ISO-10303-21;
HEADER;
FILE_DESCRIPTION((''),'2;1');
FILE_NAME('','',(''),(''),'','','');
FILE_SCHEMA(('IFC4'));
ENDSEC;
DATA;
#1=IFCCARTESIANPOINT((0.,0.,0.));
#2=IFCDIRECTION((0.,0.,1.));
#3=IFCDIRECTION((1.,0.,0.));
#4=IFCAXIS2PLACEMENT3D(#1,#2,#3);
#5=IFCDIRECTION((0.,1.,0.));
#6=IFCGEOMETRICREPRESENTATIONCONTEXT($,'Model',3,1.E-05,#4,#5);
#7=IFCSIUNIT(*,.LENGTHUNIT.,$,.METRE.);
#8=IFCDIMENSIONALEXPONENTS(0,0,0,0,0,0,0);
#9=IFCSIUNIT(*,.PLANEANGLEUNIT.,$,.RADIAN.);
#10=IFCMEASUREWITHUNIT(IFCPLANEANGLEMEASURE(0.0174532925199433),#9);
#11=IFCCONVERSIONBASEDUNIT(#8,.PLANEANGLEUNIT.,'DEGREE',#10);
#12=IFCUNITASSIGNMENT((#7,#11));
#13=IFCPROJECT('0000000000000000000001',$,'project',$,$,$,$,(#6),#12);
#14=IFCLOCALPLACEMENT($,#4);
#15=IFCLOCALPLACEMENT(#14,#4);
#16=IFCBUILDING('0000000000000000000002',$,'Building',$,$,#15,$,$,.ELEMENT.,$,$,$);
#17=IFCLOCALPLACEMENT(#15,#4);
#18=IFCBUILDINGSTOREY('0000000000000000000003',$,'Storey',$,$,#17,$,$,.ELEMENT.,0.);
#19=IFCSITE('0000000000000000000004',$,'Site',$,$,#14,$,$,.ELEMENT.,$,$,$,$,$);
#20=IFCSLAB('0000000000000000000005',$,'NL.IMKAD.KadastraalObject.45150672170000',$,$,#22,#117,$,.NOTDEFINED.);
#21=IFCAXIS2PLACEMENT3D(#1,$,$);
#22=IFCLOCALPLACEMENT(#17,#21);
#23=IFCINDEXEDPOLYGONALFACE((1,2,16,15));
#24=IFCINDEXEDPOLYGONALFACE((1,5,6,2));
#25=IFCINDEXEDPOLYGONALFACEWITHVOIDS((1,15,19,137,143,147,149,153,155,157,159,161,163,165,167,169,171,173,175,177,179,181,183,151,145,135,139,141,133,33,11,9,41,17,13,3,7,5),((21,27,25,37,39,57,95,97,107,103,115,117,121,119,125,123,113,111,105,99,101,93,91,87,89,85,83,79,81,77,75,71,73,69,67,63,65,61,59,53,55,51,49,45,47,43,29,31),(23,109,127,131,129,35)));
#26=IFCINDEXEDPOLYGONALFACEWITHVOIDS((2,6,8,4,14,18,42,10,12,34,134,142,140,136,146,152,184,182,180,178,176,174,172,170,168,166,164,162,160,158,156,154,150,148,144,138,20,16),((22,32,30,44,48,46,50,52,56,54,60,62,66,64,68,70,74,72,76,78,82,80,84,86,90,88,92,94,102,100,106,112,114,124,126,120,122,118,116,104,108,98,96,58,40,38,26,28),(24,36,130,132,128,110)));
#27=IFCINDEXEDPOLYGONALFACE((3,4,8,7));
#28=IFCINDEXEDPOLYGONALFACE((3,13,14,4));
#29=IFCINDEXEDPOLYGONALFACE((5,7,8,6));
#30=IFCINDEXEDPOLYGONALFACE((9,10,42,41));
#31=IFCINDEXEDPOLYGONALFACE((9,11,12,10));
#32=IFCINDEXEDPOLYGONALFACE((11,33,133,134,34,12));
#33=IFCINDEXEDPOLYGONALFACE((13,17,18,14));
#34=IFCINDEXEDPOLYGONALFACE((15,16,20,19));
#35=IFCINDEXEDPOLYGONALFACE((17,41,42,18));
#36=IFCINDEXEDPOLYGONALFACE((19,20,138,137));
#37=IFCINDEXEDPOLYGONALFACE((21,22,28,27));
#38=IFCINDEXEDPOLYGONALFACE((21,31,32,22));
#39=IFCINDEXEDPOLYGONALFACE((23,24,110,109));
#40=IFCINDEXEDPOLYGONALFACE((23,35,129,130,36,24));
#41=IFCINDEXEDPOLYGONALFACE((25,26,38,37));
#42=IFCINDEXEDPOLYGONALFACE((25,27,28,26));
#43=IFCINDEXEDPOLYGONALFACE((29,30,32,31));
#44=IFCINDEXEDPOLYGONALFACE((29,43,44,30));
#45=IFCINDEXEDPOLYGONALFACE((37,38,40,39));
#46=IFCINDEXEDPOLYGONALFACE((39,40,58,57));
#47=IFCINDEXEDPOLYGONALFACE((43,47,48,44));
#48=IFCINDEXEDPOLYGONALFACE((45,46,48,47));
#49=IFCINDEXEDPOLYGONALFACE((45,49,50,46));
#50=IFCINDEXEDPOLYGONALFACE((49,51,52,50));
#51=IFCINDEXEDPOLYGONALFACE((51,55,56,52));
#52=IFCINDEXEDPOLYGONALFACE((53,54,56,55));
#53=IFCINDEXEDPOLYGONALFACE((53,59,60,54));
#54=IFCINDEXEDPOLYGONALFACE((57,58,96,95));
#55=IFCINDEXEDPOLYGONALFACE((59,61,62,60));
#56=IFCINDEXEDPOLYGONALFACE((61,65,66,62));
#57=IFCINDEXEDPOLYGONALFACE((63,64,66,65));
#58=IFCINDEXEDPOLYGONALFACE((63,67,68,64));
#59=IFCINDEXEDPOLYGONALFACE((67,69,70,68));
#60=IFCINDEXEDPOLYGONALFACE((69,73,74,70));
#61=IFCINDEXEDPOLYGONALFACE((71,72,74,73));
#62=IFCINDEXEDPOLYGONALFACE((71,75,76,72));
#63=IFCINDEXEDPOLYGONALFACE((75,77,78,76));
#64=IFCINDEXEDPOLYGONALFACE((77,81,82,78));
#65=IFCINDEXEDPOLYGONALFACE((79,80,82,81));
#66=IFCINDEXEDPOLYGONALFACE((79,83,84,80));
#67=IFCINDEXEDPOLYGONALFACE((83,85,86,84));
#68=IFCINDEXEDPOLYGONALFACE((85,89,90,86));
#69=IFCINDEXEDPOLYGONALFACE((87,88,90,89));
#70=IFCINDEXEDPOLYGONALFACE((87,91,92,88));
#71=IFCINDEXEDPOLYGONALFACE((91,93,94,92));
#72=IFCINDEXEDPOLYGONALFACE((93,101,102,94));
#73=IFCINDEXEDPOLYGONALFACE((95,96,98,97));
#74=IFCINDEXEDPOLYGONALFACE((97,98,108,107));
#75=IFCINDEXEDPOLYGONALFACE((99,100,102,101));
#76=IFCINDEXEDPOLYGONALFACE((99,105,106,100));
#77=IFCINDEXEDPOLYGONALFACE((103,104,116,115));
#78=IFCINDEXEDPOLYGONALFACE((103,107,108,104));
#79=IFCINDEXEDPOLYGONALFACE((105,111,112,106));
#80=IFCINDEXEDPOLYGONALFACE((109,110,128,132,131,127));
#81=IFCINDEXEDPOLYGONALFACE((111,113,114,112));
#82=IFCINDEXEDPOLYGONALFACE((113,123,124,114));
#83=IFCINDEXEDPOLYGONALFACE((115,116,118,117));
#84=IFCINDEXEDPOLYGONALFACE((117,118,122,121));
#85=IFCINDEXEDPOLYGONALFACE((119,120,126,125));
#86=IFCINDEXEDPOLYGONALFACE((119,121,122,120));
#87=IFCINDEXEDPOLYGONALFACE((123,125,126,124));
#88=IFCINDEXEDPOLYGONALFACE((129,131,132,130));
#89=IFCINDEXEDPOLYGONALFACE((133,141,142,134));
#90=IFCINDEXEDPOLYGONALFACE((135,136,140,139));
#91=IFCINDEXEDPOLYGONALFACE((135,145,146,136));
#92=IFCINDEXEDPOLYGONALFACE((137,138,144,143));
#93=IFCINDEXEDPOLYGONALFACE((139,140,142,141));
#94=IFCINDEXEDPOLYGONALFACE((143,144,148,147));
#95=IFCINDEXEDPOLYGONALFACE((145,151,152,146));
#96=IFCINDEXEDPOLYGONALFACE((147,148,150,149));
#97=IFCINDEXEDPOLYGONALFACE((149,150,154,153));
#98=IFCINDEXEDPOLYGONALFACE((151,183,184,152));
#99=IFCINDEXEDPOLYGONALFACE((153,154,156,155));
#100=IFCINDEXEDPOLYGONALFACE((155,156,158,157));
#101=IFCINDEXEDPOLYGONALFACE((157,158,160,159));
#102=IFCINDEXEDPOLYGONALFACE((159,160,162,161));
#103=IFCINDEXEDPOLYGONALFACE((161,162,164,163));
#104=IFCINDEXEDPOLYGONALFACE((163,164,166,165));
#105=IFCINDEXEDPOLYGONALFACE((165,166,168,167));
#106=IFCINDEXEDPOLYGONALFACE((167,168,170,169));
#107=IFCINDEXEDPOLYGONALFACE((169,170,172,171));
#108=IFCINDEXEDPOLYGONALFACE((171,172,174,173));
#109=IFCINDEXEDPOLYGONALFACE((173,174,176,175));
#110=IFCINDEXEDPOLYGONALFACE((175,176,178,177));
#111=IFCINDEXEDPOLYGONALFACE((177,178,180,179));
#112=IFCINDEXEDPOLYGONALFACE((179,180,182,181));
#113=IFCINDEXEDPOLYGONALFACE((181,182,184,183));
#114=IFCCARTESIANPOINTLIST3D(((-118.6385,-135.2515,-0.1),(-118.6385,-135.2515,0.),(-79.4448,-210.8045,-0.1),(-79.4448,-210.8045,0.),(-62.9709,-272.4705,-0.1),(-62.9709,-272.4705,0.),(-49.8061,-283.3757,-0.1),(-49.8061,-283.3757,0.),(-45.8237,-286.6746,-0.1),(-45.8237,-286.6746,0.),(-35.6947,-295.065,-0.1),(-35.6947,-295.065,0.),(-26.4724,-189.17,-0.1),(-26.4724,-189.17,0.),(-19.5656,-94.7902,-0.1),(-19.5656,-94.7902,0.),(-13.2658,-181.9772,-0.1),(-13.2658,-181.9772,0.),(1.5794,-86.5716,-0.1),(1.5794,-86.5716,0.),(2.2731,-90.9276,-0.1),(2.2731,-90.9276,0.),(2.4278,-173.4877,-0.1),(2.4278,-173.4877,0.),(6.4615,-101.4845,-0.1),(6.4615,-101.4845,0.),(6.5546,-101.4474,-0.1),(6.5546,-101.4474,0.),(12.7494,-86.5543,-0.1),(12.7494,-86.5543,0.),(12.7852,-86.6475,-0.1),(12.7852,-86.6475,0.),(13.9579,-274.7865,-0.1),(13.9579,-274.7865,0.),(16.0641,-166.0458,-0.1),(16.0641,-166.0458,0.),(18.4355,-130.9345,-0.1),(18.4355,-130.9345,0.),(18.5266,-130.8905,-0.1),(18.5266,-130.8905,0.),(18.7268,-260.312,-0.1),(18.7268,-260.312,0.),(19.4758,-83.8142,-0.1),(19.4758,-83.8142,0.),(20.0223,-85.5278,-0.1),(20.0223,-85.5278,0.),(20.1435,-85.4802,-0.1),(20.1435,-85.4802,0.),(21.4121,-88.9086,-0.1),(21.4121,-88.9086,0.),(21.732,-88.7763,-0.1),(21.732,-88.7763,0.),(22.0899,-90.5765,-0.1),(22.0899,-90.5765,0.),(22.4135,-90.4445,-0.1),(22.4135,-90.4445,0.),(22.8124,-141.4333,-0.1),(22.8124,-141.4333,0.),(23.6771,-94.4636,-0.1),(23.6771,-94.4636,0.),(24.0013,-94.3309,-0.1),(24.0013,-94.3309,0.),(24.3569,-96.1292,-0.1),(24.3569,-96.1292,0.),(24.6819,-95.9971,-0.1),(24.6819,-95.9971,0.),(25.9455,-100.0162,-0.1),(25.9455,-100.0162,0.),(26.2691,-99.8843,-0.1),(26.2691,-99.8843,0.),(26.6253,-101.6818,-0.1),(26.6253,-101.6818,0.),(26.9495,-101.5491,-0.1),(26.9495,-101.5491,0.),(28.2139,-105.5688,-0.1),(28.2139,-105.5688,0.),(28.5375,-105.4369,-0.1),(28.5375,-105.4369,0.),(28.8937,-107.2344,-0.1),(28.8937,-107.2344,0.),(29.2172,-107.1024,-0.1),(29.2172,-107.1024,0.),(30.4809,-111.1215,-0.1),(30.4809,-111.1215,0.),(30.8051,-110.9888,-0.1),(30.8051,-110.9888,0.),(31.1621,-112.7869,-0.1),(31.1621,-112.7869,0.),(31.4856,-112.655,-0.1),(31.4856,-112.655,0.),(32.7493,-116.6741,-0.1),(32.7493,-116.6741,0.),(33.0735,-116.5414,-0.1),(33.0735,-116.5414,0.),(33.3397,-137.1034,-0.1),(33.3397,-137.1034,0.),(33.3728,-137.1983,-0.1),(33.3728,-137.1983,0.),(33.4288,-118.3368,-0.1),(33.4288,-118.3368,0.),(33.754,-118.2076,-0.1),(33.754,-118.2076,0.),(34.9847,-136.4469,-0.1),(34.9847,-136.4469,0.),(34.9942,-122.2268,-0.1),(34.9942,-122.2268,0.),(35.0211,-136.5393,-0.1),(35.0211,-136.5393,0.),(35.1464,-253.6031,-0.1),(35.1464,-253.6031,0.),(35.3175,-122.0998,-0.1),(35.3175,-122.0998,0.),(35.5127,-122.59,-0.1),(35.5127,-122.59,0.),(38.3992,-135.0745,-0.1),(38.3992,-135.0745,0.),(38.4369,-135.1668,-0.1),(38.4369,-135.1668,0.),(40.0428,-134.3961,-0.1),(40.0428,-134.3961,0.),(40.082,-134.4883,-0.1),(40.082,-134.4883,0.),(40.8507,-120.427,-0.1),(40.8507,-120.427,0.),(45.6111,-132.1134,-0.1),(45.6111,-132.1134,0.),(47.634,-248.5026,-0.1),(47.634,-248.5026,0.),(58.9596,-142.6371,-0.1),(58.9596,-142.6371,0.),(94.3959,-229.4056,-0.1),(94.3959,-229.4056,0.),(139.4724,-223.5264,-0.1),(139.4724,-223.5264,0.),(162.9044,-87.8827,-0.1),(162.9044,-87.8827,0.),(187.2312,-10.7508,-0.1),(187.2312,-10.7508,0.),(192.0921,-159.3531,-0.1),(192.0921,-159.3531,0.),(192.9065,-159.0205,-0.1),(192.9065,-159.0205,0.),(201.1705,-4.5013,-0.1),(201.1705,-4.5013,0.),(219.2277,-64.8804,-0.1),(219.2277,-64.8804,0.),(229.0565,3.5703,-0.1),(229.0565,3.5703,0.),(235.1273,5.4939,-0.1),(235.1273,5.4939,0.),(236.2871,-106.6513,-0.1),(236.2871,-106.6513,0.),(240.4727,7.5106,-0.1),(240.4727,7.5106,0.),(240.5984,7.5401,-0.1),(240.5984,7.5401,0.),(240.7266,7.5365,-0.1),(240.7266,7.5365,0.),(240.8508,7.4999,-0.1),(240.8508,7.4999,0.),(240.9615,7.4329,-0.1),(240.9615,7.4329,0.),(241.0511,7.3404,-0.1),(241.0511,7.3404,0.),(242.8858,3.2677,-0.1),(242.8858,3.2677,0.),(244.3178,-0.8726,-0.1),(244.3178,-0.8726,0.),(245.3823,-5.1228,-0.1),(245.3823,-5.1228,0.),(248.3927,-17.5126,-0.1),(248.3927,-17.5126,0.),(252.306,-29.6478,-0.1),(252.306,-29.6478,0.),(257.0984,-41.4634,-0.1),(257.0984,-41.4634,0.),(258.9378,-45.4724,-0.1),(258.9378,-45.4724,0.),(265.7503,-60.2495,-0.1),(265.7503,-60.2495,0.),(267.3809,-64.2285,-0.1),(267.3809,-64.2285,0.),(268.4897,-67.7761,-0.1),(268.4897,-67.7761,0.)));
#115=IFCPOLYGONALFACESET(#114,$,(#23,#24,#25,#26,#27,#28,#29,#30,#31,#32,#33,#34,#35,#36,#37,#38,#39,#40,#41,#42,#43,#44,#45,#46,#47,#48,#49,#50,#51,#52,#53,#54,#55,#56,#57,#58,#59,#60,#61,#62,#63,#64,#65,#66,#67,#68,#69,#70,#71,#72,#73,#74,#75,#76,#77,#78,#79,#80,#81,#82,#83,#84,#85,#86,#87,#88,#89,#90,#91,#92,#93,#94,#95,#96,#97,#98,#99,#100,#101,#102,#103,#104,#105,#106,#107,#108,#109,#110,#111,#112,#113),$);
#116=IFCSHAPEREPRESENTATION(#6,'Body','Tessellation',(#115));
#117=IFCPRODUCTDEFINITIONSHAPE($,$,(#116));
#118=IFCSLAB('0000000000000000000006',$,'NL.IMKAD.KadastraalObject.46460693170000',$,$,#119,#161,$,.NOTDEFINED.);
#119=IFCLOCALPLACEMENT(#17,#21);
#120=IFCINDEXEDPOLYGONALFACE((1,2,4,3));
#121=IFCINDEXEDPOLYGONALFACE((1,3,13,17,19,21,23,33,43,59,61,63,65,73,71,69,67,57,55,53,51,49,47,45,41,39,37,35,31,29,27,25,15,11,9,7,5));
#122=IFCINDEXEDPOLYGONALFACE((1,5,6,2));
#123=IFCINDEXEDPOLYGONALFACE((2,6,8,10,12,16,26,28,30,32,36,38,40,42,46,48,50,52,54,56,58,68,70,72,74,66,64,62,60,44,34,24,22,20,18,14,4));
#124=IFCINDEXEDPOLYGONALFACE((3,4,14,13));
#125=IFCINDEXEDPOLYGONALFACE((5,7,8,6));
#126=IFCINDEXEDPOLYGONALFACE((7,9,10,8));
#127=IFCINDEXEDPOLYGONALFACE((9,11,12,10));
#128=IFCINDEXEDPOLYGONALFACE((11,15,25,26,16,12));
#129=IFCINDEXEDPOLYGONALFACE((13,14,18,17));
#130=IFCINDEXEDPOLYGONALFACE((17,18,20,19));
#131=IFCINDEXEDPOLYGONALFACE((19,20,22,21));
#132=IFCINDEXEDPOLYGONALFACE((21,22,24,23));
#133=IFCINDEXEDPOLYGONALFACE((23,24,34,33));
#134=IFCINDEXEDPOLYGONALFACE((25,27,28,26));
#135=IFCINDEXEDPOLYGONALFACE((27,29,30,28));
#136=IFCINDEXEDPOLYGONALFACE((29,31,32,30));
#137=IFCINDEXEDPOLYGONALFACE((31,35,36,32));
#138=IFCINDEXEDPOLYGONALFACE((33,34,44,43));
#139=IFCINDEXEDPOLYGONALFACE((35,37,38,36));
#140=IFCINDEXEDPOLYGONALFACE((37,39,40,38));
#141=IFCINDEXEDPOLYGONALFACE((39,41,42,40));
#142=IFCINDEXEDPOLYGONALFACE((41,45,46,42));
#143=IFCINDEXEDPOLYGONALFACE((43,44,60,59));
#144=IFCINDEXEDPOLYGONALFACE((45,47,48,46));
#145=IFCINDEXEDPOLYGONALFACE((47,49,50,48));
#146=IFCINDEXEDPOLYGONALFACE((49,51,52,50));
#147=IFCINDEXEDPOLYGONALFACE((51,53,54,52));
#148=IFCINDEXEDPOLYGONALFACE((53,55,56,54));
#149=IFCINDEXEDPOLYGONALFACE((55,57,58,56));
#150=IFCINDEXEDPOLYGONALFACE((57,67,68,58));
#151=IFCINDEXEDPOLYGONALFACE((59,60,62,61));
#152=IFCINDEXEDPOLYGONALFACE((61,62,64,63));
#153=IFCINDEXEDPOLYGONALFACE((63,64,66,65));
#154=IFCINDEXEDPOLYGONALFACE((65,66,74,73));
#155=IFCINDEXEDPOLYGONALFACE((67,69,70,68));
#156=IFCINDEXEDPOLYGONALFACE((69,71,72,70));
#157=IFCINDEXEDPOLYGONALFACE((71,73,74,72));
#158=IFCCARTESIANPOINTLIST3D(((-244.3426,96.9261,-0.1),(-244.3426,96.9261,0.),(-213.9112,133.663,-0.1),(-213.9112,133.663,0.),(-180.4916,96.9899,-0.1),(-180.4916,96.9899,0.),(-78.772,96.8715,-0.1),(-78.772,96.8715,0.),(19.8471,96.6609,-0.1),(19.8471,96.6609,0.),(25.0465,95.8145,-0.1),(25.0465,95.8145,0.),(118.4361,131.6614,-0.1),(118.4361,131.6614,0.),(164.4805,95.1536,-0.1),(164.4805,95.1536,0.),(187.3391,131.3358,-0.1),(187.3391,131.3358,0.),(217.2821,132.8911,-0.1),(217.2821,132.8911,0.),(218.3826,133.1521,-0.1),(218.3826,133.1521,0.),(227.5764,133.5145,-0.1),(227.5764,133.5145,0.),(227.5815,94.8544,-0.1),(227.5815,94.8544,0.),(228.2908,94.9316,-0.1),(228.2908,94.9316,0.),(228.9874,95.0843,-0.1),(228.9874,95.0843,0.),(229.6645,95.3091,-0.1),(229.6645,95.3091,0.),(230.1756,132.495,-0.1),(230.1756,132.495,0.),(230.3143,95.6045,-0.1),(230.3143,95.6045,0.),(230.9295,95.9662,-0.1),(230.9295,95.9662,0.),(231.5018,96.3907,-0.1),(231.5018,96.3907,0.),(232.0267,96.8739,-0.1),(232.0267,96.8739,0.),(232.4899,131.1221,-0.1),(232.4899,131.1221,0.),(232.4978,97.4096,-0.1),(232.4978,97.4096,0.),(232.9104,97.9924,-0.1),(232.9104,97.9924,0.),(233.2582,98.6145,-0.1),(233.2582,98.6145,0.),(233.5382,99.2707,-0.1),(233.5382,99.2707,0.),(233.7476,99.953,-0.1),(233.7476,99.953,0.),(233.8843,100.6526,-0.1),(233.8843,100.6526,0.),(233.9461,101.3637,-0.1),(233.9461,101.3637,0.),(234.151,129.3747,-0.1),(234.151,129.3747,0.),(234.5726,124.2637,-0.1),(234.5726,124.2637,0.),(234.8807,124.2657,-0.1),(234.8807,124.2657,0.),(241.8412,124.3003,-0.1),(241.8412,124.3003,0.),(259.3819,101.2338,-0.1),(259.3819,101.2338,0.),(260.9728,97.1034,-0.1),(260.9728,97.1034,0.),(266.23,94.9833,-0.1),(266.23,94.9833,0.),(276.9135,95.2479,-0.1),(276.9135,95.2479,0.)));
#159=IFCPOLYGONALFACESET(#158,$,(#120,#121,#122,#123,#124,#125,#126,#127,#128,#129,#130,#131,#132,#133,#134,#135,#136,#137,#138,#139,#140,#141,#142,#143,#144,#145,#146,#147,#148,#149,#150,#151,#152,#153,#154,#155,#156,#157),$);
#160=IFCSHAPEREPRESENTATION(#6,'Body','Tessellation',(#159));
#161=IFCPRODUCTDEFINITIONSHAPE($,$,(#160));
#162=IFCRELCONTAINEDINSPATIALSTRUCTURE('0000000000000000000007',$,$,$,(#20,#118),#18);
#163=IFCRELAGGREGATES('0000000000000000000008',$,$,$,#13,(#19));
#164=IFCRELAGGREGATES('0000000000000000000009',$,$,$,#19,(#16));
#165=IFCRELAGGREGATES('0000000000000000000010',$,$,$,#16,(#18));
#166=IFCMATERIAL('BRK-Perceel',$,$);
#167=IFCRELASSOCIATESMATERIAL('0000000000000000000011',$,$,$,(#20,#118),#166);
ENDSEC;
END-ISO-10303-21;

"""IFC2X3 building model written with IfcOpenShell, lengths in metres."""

from ifc_helpers import new_model, entity, si_unit, converted_unit, direction, frame, origin_with_axes, place, context, project, spatial, polyline, outline, extrude, material, element, save


model = new_model("IFC2X3")

# Units and contexts
model_context = context("Model", 3, precision=1e-05, world=origin_with_axes(), true_north=direction((0.0, 1.0, 0.0)))
ifc_project = project(units=[si_unit("LENGTHUNIT", "METRE"), converted_unit("PLANEANGLEUNIT", "DEGREE", entity("IfcPlaneAngleMeasure", 0.0174532925199433), si_unit("PLANEANGLEUNIT", "RADIAN"), dimensions=[0, 0, 0, 0, 0, 0, 0])], contexts=[model_context])

# Site, building, storey
site_placement = place(None, origin_with_axes())
site = spatial("IfcSite", under=ifc_project, at=site_placement, Name="Site", CompositionType="ELEMENT")
building_placement = place(site_placement, origin_with_axes())
building = spatial("IfcBuilding", under=site, at=building_placement, Name="Building", CompositionType="ELEMENT")
storey_placement = place(building_placement, origin_with_axes())
storey = spatial("IfcBuildingStorey", under=building, at=storey_placement, Name="Storey", CompositionType="ELEMENT", Elevation=0.0)

# Slabs
ifc_material = material(Name="BRK-Perceel")
slab_1_placement = place(storey_placement, frame((0.0, 0.0, -0.1), z_axis=(0.0, 0.0, 1.0), x_axis=(1.0, 0.0, 0.0)))
element("IfcSlab", 1, at=slab_1_placement, inside=storey, material=ifc_material, Name="NL.IMKAD.KadastraalObject.45150672170000", PredefinedType="NOTDEFINED", context=model_context, shape_type="SweptSolid", body=[
    extrude(outline(polyline([(13.9579, -274.7865), (-35.6947, -295.065), (-45.8237, -286.6746), (18.7268, -260.312), (-13.2658, -181.9772), (-26.4724, -189.17), (-79.4448, -210.8045), (-49.8061, -283.3757), (-62.9709, -272.4705), (-118.6385, -135.2515), (-19.5656, -94.7902), (1.5794, -86.5716), (187.2312, -10.7508), (201.1705, -4.5013), (229.0565, 3.5703), (235.1273, 5.4939), (240.4727, 7.5106), (240.5984, 7.5401), (240.7266, 7.5365), (240.8508, 7.4999), (240.9615, 7.4329), (241.0511, 7.3404), (242.8858, 3.2677), (244.3178, -0.8726), (245.3823, -5.1228), (248.3927, -17.5126), (252.306, -29.6478), (257.0984, -41.4634), (258.9378, -45.4724), (265.7503, -60.2495), (267.3809, -64.2285), (268.4897, -67.7761), (236.2871, -106.6513), (219.2277, -64.8804), (162.9044, -87.8827), (192.0921, -159.3531), (192.9065, -159.0205), (139.4724, -223.5264), (13.9579, -274.7865)]), holes=[polyline([(94.3959, -229.4056), (58.9596, -142.6371), (16.0641, -166.0458), (2.4278, -173.4877), (35.1464, -253.6031), (47.634, -248.5026), (94.3959, -229.4056)]), polyline([(33.3397, -137.1034), (33.3728, -137.1983), (35.0211, -136.5393), (34.9847, -136.4469), (38.3992, -135.0745), (38.4369, -135.1668), (40.082, -134.4883), (40.0428, -134.3961), (45.6111, -132.1134), (40.8507, -120.427), (35.5127, -122.59), (35.3175, -122.0998), (34.9942, -122.2268), (33.4288, -118.3368), (33.754, -118.2076), (33.0735, -116.5414), (32.7493, -116.6741), (31.1621, -112.7869), (31.4856, -112.655), (30.8051, -110.9888), (30.4809, -111.1215), (28.8937, -107.2344), (29.2172, -107.1024), (28.5375, -105.4369), (28.2139, -105.5688), (26.6253, -101.6818), (26.9495, -101.5491), (26.2691, -99.8843), (25.9455, -100.0162), (24.3569, -96.1292), (24.6819, -95.9971), (24.0013, -94.3309), (23.6771, -94.4636), (22.0899, -90.5765), (22.4135, -90.4445), (21.732, -88.7763), (21.4121, -88.9086), (20.0223, -85.5278), (20.1435, -85.4802), (19.4758, -83.8142), (12.7494, -86.5543), (12.7852, -86.6475), (2.2731, -90.9276), (6.5546, -101.4474), (6.4615, -101.4845), (18.4355, -130.9345), (18.5266, -130.8905), (22.8124, -141.4333), (33.3397, -137.1034)])]), origin_with_axes(), (0.0, 0.0, 1.0), 0.1),
])
slab_2_placement = place(storey_placement, frame((0.0, 0.0, -0.1), z_axis=(0.0, 0.0, 1.0), x_axis=(1.0, 0.0, 0.0)))
element("IfcSlab", 2, at=slab_2_placement, inside=storey, material=ifc_material, Name="NL.IMKAD.KadastraalObject.46460693170000", PredefinedType="NOTDEFINED", context=model_context, shape_type="SweptSolid", body=[
    extrude(outline(polyline([(266.23, 94.9833), (260.9728, 97.1034), (259.3819, 101.2338), (233.9461, 101.3637), (233.8843, 100.6526), (233.7476, 99.953), (233.5382, 99.2707), (233.2582, 98.6145), (232.9104, 97.9924), (232.4978, 97.4096), (232.0267, 96.8739), (231.5018, 96.3907), (230.9295, 95.9662), (230.3143, 95.6045), (229.6645, 95.3091), (228.9874, 95.0843), (228.2908, 94.9316), (227.5815, 94.8544), (164.4805, 95.1536), (25.0465, 95.8145), (19.8471, 96.6609), (-78.772, 96.8715), (-180.4916, 96.9899), (-244.3426, 96.9261), (-213.9112, 133.663), (118.4361, 131.6614), (187.3391, 131.3358), (217.2821, 132.8911), (218.3826, 133.1521), (227.5764, 133.5145), (230.1756, 132.495), (232.4899, 131.1221), (234.151, 129.3747), (234.5726, 124.2637), (234.8807, 124.2657), (241.8412, 124.3003), (276.9135, 95.2479), (266.23, 94.9833)])), origin_with_axes(), (0.0, 0.0, 1.0), 0.1),
])

save(model, "model.ifc")
